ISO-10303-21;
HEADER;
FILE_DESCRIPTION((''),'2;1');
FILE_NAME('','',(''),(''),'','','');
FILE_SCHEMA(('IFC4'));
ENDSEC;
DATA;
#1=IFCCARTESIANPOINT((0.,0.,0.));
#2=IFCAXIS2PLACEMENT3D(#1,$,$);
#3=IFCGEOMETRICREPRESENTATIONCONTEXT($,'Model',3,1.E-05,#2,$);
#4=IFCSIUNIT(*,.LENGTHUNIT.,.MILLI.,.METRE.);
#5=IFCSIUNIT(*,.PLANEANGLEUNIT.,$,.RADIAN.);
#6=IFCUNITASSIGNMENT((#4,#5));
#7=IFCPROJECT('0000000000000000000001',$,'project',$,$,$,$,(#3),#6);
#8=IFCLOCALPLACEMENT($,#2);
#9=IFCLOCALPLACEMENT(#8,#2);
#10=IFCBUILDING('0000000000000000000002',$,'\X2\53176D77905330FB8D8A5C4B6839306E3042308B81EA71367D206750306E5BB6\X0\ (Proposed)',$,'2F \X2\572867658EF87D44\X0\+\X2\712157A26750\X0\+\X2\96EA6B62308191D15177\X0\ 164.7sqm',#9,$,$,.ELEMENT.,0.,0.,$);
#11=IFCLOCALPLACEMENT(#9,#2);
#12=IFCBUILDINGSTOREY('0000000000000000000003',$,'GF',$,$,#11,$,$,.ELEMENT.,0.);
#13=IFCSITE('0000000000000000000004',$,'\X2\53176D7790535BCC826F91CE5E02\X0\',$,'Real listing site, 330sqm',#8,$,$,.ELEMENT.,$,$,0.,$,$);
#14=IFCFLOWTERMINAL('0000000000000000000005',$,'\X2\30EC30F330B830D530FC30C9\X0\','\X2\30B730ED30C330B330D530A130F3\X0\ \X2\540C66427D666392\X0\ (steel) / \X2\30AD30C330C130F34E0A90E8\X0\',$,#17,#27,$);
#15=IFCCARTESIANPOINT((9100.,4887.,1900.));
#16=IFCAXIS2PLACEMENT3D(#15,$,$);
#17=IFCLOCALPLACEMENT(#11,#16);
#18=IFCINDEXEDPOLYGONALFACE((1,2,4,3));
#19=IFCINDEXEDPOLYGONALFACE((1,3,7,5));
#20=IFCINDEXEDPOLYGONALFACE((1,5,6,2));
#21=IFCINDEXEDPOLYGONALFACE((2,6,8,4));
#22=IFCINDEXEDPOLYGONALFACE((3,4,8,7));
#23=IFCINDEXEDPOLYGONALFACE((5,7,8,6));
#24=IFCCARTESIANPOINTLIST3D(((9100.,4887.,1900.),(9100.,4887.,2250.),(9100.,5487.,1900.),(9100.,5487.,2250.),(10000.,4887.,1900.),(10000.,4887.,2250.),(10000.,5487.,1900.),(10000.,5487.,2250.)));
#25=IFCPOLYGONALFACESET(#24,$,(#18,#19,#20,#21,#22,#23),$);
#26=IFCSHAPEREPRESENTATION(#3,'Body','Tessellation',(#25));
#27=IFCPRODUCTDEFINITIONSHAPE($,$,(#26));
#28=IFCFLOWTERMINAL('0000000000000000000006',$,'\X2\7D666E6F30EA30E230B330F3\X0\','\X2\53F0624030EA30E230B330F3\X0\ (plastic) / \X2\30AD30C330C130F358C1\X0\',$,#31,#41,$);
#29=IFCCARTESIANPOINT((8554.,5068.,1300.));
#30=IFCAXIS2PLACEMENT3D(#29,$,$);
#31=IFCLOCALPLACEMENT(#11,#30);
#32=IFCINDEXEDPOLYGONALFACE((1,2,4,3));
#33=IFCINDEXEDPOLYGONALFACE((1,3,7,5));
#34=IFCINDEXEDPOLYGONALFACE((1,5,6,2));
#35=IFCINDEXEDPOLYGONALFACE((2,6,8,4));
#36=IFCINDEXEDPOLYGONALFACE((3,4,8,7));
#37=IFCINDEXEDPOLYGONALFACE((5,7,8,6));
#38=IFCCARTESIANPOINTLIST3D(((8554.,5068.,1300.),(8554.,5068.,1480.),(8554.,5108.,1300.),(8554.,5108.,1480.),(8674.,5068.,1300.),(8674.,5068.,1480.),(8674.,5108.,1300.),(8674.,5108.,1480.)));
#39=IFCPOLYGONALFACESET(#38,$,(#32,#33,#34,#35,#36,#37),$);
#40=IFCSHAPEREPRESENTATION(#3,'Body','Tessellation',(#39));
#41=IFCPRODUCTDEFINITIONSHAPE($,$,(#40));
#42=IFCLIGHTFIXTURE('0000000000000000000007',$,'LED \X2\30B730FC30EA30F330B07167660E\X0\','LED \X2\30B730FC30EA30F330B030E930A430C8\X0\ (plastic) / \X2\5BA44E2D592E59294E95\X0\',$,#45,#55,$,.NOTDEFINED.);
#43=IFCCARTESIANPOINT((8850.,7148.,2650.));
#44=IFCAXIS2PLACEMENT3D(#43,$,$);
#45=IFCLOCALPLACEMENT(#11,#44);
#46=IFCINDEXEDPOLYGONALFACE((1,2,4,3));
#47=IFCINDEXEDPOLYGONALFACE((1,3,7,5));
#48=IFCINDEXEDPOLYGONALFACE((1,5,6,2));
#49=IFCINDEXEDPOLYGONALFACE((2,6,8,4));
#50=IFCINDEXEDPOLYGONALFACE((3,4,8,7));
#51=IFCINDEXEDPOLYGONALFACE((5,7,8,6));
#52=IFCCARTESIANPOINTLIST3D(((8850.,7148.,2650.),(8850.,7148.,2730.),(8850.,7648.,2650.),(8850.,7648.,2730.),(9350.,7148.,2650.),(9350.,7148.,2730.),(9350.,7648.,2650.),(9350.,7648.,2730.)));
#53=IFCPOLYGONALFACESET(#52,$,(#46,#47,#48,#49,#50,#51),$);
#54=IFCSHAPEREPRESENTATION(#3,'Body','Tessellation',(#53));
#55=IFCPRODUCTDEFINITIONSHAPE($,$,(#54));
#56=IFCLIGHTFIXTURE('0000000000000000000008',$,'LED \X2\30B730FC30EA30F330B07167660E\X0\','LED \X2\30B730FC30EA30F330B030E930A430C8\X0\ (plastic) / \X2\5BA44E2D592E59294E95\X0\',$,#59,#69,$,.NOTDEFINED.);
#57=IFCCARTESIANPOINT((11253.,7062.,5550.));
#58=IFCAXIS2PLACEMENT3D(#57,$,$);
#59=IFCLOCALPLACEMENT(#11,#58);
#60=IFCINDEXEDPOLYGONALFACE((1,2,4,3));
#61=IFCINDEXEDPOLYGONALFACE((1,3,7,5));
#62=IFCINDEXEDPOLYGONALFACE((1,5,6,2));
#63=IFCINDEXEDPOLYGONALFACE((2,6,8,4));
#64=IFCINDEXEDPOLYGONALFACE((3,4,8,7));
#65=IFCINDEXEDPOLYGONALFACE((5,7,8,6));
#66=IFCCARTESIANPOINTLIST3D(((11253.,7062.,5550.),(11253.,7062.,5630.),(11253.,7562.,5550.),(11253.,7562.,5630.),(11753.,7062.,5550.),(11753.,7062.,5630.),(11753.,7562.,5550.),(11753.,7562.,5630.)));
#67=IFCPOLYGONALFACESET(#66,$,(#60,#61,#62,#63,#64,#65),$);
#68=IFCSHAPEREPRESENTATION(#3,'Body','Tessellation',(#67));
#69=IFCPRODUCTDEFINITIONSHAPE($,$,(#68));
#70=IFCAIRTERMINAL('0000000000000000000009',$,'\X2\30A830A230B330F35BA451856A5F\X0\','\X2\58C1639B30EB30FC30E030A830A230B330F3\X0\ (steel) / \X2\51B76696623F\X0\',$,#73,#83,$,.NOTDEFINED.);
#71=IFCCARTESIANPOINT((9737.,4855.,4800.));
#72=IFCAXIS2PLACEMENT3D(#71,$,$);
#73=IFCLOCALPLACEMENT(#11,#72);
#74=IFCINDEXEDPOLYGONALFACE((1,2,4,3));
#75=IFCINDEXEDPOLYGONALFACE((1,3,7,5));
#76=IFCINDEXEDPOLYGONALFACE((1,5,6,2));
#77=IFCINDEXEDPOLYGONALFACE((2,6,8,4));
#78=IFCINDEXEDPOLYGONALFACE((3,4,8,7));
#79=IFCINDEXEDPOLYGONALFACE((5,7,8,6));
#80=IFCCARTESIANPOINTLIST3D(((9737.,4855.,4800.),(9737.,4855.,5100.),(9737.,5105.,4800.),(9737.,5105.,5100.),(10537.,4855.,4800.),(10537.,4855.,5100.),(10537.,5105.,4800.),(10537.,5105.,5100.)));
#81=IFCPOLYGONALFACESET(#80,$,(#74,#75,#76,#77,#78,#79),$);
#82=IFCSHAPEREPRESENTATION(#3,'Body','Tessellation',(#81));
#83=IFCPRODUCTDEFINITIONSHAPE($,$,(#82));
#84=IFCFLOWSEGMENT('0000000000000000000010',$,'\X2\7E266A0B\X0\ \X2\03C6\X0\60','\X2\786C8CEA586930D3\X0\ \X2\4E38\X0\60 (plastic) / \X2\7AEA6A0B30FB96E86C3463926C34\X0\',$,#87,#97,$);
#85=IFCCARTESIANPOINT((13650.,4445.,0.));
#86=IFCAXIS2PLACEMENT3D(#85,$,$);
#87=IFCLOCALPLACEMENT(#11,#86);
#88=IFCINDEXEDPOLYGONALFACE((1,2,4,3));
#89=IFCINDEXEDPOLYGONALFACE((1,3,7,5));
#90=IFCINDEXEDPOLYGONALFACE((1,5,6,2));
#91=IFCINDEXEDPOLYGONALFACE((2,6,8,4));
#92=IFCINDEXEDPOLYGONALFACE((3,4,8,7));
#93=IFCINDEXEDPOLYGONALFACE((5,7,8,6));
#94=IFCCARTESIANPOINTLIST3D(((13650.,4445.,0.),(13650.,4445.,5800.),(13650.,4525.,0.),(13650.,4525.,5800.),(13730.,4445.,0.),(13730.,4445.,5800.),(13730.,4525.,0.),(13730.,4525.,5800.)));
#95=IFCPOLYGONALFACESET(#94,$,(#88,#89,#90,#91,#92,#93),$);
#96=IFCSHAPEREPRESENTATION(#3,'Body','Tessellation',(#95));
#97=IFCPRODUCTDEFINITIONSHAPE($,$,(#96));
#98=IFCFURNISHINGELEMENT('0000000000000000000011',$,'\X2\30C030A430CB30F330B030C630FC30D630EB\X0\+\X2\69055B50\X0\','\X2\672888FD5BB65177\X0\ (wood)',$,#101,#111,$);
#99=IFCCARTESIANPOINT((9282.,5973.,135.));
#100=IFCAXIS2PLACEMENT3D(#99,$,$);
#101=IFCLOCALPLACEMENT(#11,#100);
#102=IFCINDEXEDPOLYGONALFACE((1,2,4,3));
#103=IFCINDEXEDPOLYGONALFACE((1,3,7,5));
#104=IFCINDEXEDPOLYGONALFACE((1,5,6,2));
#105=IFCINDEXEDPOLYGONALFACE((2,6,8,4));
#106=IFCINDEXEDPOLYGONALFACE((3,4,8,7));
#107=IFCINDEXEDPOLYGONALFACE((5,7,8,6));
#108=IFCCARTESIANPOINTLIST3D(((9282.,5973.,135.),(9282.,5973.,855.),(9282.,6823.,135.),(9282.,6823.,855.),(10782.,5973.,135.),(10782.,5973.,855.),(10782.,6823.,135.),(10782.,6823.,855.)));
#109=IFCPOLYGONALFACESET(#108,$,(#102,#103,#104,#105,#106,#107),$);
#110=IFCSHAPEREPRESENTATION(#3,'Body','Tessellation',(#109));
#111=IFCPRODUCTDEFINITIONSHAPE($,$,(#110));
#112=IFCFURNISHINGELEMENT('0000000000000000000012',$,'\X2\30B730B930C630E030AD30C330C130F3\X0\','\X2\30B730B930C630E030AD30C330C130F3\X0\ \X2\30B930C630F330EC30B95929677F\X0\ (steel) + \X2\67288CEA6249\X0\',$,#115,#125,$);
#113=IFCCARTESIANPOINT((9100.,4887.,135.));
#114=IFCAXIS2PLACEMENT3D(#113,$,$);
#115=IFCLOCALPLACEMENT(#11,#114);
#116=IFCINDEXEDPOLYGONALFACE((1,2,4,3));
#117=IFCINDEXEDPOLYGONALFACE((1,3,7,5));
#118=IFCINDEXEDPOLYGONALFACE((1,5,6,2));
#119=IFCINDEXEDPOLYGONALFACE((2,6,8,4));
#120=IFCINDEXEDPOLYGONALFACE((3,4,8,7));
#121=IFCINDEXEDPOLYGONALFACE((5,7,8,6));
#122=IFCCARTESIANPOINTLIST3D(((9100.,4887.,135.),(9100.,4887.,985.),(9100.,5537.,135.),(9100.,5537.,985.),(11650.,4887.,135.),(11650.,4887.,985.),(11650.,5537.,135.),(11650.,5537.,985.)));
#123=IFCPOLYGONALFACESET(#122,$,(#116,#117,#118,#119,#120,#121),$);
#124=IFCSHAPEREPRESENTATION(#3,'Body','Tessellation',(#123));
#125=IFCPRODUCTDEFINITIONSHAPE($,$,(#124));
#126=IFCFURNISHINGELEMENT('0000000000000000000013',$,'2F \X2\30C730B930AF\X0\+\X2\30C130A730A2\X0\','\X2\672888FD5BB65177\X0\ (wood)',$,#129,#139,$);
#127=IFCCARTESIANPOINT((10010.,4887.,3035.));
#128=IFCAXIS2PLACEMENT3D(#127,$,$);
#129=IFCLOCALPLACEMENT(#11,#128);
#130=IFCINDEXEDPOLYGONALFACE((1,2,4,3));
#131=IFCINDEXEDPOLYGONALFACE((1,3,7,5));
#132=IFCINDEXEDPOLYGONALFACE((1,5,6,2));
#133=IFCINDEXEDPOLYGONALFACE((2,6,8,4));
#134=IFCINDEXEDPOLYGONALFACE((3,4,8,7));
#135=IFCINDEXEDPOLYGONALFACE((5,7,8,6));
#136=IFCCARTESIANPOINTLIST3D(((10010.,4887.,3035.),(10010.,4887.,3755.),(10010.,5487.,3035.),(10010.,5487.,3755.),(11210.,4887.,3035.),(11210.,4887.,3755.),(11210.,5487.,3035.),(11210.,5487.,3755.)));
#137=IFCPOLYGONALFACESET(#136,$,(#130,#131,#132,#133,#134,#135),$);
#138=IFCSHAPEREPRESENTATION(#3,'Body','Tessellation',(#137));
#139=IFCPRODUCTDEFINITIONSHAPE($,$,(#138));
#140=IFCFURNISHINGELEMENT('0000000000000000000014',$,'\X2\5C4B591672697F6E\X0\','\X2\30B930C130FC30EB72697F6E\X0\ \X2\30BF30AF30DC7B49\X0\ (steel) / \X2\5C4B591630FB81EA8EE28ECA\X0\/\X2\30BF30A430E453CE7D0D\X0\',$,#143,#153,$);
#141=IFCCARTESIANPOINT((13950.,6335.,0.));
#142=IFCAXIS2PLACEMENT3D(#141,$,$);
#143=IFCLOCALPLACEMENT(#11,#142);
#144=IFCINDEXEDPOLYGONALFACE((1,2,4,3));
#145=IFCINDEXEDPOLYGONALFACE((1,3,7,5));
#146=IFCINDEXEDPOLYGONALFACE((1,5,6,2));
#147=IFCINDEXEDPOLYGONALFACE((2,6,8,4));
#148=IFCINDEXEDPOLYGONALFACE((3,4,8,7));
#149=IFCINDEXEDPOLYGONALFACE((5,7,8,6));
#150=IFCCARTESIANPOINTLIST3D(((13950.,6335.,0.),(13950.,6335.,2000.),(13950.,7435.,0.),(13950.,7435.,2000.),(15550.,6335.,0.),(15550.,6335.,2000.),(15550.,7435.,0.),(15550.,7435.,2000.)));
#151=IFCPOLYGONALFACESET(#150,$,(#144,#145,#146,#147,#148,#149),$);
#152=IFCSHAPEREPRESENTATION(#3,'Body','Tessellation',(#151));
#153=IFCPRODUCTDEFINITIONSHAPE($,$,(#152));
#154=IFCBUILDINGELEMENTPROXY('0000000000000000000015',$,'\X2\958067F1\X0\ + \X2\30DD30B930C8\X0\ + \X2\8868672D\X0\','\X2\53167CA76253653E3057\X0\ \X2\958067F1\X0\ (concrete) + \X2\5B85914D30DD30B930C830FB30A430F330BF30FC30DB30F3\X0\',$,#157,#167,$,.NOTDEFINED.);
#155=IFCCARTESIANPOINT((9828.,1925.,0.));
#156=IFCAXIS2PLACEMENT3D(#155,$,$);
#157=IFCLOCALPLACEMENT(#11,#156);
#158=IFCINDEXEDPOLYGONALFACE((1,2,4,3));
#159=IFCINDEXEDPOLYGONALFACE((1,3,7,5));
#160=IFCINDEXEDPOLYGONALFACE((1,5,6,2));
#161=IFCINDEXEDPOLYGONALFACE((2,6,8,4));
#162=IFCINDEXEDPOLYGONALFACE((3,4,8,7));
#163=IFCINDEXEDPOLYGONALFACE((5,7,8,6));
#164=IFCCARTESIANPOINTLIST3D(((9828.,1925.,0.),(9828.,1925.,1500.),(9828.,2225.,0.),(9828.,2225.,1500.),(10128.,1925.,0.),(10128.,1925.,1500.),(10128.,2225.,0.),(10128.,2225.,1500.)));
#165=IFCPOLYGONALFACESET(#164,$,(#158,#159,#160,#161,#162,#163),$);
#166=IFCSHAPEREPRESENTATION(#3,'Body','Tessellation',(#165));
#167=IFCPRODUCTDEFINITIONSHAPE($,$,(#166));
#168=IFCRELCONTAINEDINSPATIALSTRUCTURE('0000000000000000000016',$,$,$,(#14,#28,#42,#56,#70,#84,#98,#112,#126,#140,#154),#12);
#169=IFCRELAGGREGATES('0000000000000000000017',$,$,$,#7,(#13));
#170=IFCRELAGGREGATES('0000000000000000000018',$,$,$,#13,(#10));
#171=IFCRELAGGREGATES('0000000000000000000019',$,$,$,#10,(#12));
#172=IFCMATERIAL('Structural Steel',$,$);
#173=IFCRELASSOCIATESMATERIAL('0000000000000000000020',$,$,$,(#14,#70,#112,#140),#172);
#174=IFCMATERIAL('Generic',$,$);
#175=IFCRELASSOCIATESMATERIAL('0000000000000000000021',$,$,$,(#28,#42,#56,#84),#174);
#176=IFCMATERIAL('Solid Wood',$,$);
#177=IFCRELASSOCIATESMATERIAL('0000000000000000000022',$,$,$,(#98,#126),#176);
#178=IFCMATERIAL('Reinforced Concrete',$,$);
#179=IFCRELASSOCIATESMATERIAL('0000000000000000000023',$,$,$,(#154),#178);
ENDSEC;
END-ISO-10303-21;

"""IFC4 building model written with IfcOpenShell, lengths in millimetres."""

from ifc_helpers import new_model, si_unit, frame, frame_2d, origin, place, context, project, spatial, rectangle, extrude, material, element, save


model = new_model("IFC4")

# Units and contexts
model_context = context("Model", 3, precision=1e-05, world=origin())
ifc_project = project(units=[si_unit("LENGTHUNIT", "METRE", prefix="MILLI"), si_unit("PLANEANGLEUNIT", "RADIAN")], contexts=[model_context])

# Site, building, storey
site_placement = place(None, origin())
site = spatial("IfcSite", under=ifc_project, at=site_placement, Name="北海道富良野市", ObjectType="Real listing site, 330sqm", CompositionType="ELEMENT", RefElevation=0.0)
building_placement = place(site_placement, origin())
building = spatial("IfcBuilding", under=site, at=building_placement, Name="北海道・越屋根のある自然素材の家 (Proposed)", ObjectType="2F 在来軸組+無垢材+雪止め金具 164.7sqm", CompositionType="ELEMENT", ElevationOfRefHeight=0.0, ElevationOfTerrain=0.0)
storey_placement = place(building_placement, origin())
storey = spatial("IfcBuildingStorey", under=building, at=storey_placement, Name="GF", CompositionType="ELEMENT", Elevation=0.0)

# Shared definitions
ifc_material_1 = material(Name="Solid Wood")

# Shared definitions
ifc_material_2 = material(Name="Reinforced Concrete")

# Shared definitions
ifc_material_3 = material(Name="Structural Steel")

# Flow terminals
flow_terminal_1_placement = place(storey_placement, frame((9100.0, 4887.0, 1900.0)))
element("IfcFlowTerminal", 1, at=flow_terminal_1_placement, inside=storey, material=ifc_material_3, Name="レンジフード", Description="シロッコファン 同時給排 (steel) / キッチン上部", context=model_context, shape_type="SweptSolid", body=[
    extrude(rectangle(XDim=900.0, YDim=600.0, at=frame_2d((450.0, 300.0))), frame((9100.0, 4887.0, 1900.0)), (0.0, 0.0, 1.0), 350.0),
])
ifc_material_4 = material(Name="Generic")
flow_terminal_2_placement = place(storey_placement, frame((8554.0, 5068.0, 1300.0)))
element("IfcFlowTerminal", 2, at=flow_terminal_2_placement, inside=storey, material=ifc_material_4, Name="給湯リモコン", Description="台所リモコン (plastic) / キッチン壁", context=model_context, shape_type="SweptSolid", body=[
    extrude(rectangle(XDim=120.0, YDim=40.0, at=frame_2d((60.0, 20.0))), frame((8554.0, 5068.0, 1300.0)), (0.0, 0.0, 1.0), 180.0),
])

# Light fixtures
light_fixture_1_placement = place(storey_placement, frame((8850.0, 7148.0, 2650.0)))
element("IfcLightFixture", 3, at=light_fixture_1_placement, inside=storey, material=ifc_material_4, Name="LED シーリング照明", Description="LED シーリングライト (plastic) / 室中央天井", PredefinedType="NOTDEFINED", context=model_context, shape_type="SweptSolid", body=[
    extrude(rectangle(XDim=500.0, YDim=500.0, at=frame_2d((250.0, 250.0))), frame((8850.0, 7148.0, 2650.0)), (0.0, 0.0, 1.0), 80.0),
])
light_fixture_2_placement = place(storey_placement, frame((11253.0, 7062.0, 5550.0)))
element("IfcLightFixture", 4, at=light_fixture_2_placement, inside=storey, material=ifc_material_4, Name="LED シーリング照明", Description="LED シーリングライト (plastic) / 室中央天井", PredefinedType="NOTDEFINED", context=model_context, shape_type="SweptSolid", body=[
    extrude(rectangle(XDim=500.0, YDim=500.0, at=frame_2d((250.0, 250.0))), frame((11253.0, 7062.0, 5550.0)), (0.0, 0.0, 1.0), 80.0),
])

# Air terminal
air_terminal_placement = place(storey_placement, frame((9737.0, 4855.0, 4800.0)))
element("IfcAirTerminal", 5, at=air_terminal_placement, inside=storey, material=ifc_material_3, Name="エアコン室内機", Description="壁掛ルームエアコン (steel) / 冷暖房", PredefinedType="NOTDEFINED", context=model_context, shape_type="SweptSolid", body=[
    extrude(rectangle(XDim=800.0, YDim=250.0, at=frame_2d((400.0, 125.0))), frame((9737.0, 4855.0, 4800.0)), (0.0, 0.0, 1.0), 300.0),
])

# Flow segment
flow_segment_placement = place(storey_placement, frame((13650.0, 4445.0, 0.0)))
element("IfcFlowSegment", 6, at=flow_segment_placement, inside=storey, material=ifc_material_4, Name="縦樋 φ60", Description="硬質塩ビ 丸60 (plastic) / 竪樋・雨水排水", context=model_context, shape_type="SweptSolid", body=[
    extrude(rectangle(XDim=80.0, YDim=80.0, at=frame_2d((40.0, 40.0))), frame((13650.0, 4445.0, 0.0)), (0.0, 0.0, 1.0), 5800.0),
])

# Furnishing elements
furnishing_1_placement = place(storey_placement, frame((9282.0, 5973.0, 135.0)))
element("IfcFurnishingElement", 7, at=furnishing_1_placement, inside=storey, material=ifc_material_1, Name="ダイニングテーブル+椅子", Description="木製家具 (wood)", context=model_context, shape_type="SweptSolid", body=[
    extrude(rectangle(XDim=1500.0, YDim=850.0, at=frame_2d((750.0, 425.0))), frame((9282.0, 5973.0, 135.0)), (0.0, 0.0, 1.0), 720.0),
])
furnishing_2_placement = place(storey_placement, frame((9100.0, 4887.0, 135.0)))
element("IfcFurnishingElement", 8, at=furnishing_2_placement, inside=storey, material=ifc_material_3, Name="システムキッチン", Description="システムキッチン ステンレス天板 (steel) + 木質扉", context=model_context, shape_type="SweptSolid", body=[
    extrude(rectangle(XDim=2550.0, YDim=650.0, at=frame_2d((1275.0, 325.0))), frame((9100.0, 4887.0, 135.0)), (0.0, 0.0, 1.0), 850.0),
])
furnishing_3_placement = place(storey_placement, frame((10010.0, 4887.0, 3035.0)))
element("IfcFurnishingElement", 9, at=furnishing_3_placement, inside=storey, material=ifc_material_1, Name="2F デスク+チェア", Description="木製家具 (wood)", context=model_context, shape_type="SweptSolid", body=[
    extrude(rectangle(XDim=1200.0, YDim=600.0, at=frame_2d((600.0, 300.0))), frame((10010.0, 4887.0, 3035.0)), (0.0, 0.0, 1.0), 720.0),
])
furnishing_4_placement = place(storey_placement, frame((13950.0, 6335.0, 0.0)))
element("IfcFurnishingElement", 10, at=furnishing_4_placement, inside=storey, material=ifc_material_3, Name="屋外物置", Description="スチール物置 タクボ等 (steel) / 屋外・自転車/タイヤ収納", context=model_context, shape_type="SweptSolid", body=[
    extrude(rectangle(XDim=1600.0, YDim=1100.0, at=frame_2d((800.0, 550.0))), frame((13950.0, 6335.0, 0.0)), (0.0, 0.0, 1.0), 2000.0),
])

# Building element proxy
proxy_placement = place(storey_placement, frame((9828.0, 1925.0, 0.0)))
element("IfcBuildingElementProxy", 11, at=proxy_placement, inside=storey, material=ifc_material_2, Name="門柱 + ポスト + 表札", Description="化粧打放し 門柱 (concrete) + 宅配ポスト・インターホン", PredefinedType="NOTDEFINED", context=model_context, shape_type="SweptSolid", body=[
    extrude(rectangle(XDim=300.0, YDim=300.0, at=frame_2d((150.0, 150.0))), frame((9828.0, 1925.0, 0.0)), (0.0, 0.0, 1.0), 1500.0),
])

save(model, "model.ifc")
